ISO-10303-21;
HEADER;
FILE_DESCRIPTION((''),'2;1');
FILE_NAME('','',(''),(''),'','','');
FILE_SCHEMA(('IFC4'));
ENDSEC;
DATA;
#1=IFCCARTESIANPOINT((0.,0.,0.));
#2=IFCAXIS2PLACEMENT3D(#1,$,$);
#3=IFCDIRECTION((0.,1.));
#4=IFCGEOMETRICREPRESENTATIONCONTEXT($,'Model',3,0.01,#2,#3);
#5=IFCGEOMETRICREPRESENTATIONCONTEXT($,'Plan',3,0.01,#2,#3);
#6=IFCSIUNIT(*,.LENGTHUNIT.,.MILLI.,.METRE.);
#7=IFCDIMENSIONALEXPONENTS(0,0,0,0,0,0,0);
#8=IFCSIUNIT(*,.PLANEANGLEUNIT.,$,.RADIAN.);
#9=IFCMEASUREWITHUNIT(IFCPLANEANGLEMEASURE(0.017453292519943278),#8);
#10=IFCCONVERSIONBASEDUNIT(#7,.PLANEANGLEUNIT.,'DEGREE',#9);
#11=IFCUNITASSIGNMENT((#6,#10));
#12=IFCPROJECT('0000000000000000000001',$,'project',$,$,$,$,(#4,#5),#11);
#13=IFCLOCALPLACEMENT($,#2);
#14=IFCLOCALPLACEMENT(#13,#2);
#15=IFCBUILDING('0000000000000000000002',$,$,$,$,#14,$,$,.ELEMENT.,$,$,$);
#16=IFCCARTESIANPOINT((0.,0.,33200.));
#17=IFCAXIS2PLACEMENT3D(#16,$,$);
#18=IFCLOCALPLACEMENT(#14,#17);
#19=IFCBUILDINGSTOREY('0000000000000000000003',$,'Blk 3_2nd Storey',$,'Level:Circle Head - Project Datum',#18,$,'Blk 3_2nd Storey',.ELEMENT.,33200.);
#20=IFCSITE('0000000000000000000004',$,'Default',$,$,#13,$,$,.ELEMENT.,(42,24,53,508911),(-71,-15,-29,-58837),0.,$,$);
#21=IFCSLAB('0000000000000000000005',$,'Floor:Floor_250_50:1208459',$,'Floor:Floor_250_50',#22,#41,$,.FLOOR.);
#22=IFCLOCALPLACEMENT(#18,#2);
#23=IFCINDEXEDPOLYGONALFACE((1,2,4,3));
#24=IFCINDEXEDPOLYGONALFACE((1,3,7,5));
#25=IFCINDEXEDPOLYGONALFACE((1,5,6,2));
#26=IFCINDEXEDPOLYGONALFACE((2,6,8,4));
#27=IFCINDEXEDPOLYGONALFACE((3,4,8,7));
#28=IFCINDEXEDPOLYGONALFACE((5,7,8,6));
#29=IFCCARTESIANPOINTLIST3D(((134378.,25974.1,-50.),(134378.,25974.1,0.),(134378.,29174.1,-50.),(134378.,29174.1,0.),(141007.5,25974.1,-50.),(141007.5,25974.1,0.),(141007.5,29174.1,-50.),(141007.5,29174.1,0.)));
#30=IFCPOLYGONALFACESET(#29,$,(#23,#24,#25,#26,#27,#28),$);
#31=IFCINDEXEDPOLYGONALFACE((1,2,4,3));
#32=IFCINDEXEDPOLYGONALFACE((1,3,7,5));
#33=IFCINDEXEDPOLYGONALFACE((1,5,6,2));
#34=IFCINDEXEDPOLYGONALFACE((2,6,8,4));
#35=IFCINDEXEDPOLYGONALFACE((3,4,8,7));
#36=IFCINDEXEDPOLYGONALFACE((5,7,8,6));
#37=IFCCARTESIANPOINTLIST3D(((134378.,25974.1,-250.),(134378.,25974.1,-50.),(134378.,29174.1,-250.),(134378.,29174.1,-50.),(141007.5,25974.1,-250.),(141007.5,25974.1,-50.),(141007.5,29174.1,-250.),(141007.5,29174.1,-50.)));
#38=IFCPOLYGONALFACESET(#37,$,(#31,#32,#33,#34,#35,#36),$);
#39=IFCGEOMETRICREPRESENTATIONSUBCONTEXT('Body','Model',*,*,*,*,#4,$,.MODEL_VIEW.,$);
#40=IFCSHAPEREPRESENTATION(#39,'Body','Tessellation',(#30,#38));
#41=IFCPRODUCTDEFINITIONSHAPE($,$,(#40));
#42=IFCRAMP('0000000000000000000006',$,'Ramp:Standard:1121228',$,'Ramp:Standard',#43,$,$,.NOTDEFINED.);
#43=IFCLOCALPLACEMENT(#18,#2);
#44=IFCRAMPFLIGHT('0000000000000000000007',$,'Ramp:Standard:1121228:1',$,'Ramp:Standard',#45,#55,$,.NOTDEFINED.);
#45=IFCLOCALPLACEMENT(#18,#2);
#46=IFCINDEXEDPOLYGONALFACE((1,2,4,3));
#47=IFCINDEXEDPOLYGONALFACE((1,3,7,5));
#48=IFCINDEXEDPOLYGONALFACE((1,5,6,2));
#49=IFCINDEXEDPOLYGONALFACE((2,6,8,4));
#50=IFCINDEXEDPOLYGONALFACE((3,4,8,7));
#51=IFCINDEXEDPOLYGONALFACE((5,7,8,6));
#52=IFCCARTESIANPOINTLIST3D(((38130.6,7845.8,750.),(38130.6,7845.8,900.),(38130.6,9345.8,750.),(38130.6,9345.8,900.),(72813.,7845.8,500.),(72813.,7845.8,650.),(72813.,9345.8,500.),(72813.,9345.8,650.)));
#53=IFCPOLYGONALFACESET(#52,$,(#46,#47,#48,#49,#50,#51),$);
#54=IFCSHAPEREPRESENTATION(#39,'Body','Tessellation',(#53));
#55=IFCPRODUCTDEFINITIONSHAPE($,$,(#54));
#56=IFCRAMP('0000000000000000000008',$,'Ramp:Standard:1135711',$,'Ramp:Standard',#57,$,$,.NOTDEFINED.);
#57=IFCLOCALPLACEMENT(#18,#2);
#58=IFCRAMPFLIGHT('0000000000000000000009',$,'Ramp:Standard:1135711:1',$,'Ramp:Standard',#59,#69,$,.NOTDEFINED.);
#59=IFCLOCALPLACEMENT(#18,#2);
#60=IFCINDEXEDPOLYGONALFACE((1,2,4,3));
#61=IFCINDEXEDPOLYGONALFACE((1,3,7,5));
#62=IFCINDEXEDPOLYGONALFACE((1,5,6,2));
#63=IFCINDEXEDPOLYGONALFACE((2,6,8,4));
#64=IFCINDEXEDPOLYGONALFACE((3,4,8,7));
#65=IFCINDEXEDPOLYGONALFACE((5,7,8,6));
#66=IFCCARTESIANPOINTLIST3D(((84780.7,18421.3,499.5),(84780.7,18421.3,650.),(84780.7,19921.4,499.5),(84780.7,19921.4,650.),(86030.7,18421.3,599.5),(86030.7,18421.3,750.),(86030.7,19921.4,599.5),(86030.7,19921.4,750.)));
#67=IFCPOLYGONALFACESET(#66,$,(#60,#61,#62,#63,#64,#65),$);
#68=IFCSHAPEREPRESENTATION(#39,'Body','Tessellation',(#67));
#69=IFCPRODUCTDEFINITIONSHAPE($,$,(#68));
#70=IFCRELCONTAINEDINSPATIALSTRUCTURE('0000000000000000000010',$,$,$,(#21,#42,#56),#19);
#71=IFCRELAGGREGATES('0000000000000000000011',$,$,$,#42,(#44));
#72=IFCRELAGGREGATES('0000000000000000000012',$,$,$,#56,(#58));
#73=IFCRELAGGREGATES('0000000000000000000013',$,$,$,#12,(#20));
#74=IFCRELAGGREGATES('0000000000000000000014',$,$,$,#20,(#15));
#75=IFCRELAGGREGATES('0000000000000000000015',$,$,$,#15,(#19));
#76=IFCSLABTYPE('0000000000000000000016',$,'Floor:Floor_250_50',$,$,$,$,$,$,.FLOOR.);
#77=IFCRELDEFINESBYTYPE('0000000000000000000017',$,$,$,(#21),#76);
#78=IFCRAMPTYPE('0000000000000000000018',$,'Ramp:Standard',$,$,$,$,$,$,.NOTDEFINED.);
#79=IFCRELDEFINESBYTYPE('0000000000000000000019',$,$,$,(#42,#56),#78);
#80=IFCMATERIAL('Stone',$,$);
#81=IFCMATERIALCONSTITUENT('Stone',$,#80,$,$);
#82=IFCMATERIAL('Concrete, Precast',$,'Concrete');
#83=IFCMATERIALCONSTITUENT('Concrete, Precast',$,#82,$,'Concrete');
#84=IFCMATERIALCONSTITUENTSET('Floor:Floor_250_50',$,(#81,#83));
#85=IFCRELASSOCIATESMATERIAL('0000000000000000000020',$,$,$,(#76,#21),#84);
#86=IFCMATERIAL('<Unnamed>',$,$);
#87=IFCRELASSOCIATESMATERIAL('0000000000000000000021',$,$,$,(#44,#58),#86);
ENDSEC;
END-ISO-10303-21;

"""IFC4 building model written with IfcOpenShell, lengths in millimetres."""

from ifc_helpers import new_model, entity, si_unit, converted_unit, direction, frame, origin, place, context, subcontext, project, spatial, indexed_curve, outline, extrude, material, constituent, constituent_set, type_object, element, aggregate, save


model = new_model("IFC4")

# Units and contexts
model_context = context("Model", 3, precision=0.01, world=origin(), true_north=direction((0.0, 1.0)))
plan_context = context("Plan", 3, precision=0.01, world=origin(), true_north=direction((0.0, 1.0)))
body_context = subcontext(model_context, "Body", "Model", "MODEL_VIEW")
ifc_project = project(units=[si_unit("LENGTHUNIT", "METRE", prefix="MILLI"), converted_unit("PLANEANGLEUNIT", "DEGREE", entity("IfcPlaneAngleMeasure", 0.017453292519943278), si_unit("PLANEANGLEUNIT", "RADIAN"), dimensions=[0, 0, 0, 0, 0, 0, 0])], contexts=[model_context, plan_context])

# Site, building, storey
site_placement = place(None, origin())
site = spatial("IfcSite", under=ifc_project, at=site_placement, Name="Default", CompositionType="ELEMENT", RefLatitude=(42, 24, 53, 508911), RefLongitude=(-71, -15, -29, -58837), RefElevation=0.0)
building_placement = place(site_placement, origin())
building = spatial("IfcBuilding", under=site, at=building_placement, CompositionType="ELEMENT")
storey_placement = place(building_placement, frame((0.0, 0.0, 33200.0)))
storey = spatial("IfcBuildingStorey", under=building, at=storey_placement, Name="Blk 3_2nd Storey", ObjectType="Level:Circle Head - Project Datum", LongName="Blk 3_2nd Storey", CompositionType="ELEMENT", Elevation=33200.0)

# Slab
ifc_material_1 = material(Name="Stone")
ifc_constituent_1 = constituent(ifc_material_1, Name="Stone")
ifc_material_2 = material(Name="Concrete, Precast", Category="Concrete")
ifc_constituent_2 = constituent(ifc_material_2, Name="Concrete, Precast", Category="Concrete")
ifc_constituent_set = constituent_set(constituents=[ifc_constituent_1, ifc_constituent_2], Name="Floor:Floor_250_50")
slab_type = type_object("IfcSlabType", Name="Floor:Floor_250_50", PredefinedType="FLOOR", material=ifc_constituent_set)
slab_placement = place(storey_placement, origin())
element("IfcSlab", 1, at=slab_placement, inside=storey, type_object=slab_type, material=ifc_constituent_set, Name="Floor:Floor_250_50:1208459", ObjectType="Floor:Floor_250_50", PredefinedType="FLOOR", context=body_context, shape_type="SweptSolid", body=[
    extrude(outline(indexed_curve([(-1600.0, -3314.7), (1600.0, -3314.7), (1600.0, 3314.7), (-1600.0, 3314.7), (-1600.0, -3314.7)], self_intersect=False)), frame((137692.8, 27574.1, -50.0), z_axis=(0.0, 0.0, 1.0), x_axis=(0.0, 1.0, 0.0)), (0.0, 0.0, 1.0), 50.0),
    extrude(outline(indexed_curve([(-1600.0, -3314.7), (1600.0, -3314.7), (1600.0, 3314.7), (-1600.0, 3314.7), (-1600.0, -3314.7)], self_intersect=False)), frame((137692.8, 27574.1, -250.0), z_axis=(0.0, 0.0, 1.0), x_axis=(0.0, 1.0, 0.0)), (0.0, 0.0, 1.0), 200.0),
])

# Ramps, ramp flights
ramp_type = type_object("IfcRampType", Name="Ramp:Standard", PredefinedType="NOTDEFINED")
ramp_1_placement = place(storey_placement, origin())
ramp_1 = element("IfcRamp", 2, at=ramp_1_placement, inside=storey, type_object=ramp_type, Name="Ramp:Standard:1121228", ObjectType="Ramp:Standard", PredefinedType="NOTDEFINED")
ifc_material_3 = material(Name="<Unnamed>")
ramp_flight_1_placement = place(ramp_1_placement, origin())
ramp_flight_1 = element("IfcRampFlight", 3, at=ramp_flight_1_placement, material=ifc_material_3, Name="Ramp:Standard:1121228:1", ObjectType="Ramp:Standard", PredefinedType="NOTDEFINED", context=body_context, shape_type="SweptSolid", body=[
    extrude(outline(indexed_curve([(50.0, -17341.2), (200.0, -17341.2), (-50.0, 17341.2), (-200.0, 17341.2), (50.0, -17341.2)], self_intersect=False)), frame((55471.8, 7845.8, 700.0), z_axis=(0.0, 1.0, 0.0), x_axis=(0.0, 0.0, -1.0)), (0.0, 0.0, 1.0), 1500.0),
])
aggregate(ramp_1, [ramp_flight_1])
ramp_2_placement = place(storey_placement, origin())
ramp_2 = element("IfcRamp", 4, at=ramp_2_placement, inside=storey, type_object=ramp_type, Name="Ramp:Standard:1135711", ObjectType="Ramp:Standard", PredefinedType="NOTDEFINED")
ramp_flight_2_placement = place(ramp_2_placement, origin())
ramp_flight_2 = element("IfcRampFlight", 5, at=ramp_flight_2_placement, material=ifc_material_3, Name="Ramp:Standard:1135711:1", ObjectType="Ramp:Standard", PredefinedType="NOTDEFINED", context=body_context, shape_type="SweptSolid", body=[
    extrude(outline(indexed_curve([(-125.2, -625.0), (25.2, -625.0), (125.2, 625.0), (-25.2, 625.0), (-125.2, -625.0)], self_intersect=False)), frame((85405.7, 18421.3, 624.8), z_axis=(0.0, 1.0, 0.0), x_axis=(0.0, 0.0, -1.0)), (0.0, 0.0, 1.0), 1500.1),
])
aggregate(ramp_2, [ramp_flight_2])

save(model, "model.ifc")
